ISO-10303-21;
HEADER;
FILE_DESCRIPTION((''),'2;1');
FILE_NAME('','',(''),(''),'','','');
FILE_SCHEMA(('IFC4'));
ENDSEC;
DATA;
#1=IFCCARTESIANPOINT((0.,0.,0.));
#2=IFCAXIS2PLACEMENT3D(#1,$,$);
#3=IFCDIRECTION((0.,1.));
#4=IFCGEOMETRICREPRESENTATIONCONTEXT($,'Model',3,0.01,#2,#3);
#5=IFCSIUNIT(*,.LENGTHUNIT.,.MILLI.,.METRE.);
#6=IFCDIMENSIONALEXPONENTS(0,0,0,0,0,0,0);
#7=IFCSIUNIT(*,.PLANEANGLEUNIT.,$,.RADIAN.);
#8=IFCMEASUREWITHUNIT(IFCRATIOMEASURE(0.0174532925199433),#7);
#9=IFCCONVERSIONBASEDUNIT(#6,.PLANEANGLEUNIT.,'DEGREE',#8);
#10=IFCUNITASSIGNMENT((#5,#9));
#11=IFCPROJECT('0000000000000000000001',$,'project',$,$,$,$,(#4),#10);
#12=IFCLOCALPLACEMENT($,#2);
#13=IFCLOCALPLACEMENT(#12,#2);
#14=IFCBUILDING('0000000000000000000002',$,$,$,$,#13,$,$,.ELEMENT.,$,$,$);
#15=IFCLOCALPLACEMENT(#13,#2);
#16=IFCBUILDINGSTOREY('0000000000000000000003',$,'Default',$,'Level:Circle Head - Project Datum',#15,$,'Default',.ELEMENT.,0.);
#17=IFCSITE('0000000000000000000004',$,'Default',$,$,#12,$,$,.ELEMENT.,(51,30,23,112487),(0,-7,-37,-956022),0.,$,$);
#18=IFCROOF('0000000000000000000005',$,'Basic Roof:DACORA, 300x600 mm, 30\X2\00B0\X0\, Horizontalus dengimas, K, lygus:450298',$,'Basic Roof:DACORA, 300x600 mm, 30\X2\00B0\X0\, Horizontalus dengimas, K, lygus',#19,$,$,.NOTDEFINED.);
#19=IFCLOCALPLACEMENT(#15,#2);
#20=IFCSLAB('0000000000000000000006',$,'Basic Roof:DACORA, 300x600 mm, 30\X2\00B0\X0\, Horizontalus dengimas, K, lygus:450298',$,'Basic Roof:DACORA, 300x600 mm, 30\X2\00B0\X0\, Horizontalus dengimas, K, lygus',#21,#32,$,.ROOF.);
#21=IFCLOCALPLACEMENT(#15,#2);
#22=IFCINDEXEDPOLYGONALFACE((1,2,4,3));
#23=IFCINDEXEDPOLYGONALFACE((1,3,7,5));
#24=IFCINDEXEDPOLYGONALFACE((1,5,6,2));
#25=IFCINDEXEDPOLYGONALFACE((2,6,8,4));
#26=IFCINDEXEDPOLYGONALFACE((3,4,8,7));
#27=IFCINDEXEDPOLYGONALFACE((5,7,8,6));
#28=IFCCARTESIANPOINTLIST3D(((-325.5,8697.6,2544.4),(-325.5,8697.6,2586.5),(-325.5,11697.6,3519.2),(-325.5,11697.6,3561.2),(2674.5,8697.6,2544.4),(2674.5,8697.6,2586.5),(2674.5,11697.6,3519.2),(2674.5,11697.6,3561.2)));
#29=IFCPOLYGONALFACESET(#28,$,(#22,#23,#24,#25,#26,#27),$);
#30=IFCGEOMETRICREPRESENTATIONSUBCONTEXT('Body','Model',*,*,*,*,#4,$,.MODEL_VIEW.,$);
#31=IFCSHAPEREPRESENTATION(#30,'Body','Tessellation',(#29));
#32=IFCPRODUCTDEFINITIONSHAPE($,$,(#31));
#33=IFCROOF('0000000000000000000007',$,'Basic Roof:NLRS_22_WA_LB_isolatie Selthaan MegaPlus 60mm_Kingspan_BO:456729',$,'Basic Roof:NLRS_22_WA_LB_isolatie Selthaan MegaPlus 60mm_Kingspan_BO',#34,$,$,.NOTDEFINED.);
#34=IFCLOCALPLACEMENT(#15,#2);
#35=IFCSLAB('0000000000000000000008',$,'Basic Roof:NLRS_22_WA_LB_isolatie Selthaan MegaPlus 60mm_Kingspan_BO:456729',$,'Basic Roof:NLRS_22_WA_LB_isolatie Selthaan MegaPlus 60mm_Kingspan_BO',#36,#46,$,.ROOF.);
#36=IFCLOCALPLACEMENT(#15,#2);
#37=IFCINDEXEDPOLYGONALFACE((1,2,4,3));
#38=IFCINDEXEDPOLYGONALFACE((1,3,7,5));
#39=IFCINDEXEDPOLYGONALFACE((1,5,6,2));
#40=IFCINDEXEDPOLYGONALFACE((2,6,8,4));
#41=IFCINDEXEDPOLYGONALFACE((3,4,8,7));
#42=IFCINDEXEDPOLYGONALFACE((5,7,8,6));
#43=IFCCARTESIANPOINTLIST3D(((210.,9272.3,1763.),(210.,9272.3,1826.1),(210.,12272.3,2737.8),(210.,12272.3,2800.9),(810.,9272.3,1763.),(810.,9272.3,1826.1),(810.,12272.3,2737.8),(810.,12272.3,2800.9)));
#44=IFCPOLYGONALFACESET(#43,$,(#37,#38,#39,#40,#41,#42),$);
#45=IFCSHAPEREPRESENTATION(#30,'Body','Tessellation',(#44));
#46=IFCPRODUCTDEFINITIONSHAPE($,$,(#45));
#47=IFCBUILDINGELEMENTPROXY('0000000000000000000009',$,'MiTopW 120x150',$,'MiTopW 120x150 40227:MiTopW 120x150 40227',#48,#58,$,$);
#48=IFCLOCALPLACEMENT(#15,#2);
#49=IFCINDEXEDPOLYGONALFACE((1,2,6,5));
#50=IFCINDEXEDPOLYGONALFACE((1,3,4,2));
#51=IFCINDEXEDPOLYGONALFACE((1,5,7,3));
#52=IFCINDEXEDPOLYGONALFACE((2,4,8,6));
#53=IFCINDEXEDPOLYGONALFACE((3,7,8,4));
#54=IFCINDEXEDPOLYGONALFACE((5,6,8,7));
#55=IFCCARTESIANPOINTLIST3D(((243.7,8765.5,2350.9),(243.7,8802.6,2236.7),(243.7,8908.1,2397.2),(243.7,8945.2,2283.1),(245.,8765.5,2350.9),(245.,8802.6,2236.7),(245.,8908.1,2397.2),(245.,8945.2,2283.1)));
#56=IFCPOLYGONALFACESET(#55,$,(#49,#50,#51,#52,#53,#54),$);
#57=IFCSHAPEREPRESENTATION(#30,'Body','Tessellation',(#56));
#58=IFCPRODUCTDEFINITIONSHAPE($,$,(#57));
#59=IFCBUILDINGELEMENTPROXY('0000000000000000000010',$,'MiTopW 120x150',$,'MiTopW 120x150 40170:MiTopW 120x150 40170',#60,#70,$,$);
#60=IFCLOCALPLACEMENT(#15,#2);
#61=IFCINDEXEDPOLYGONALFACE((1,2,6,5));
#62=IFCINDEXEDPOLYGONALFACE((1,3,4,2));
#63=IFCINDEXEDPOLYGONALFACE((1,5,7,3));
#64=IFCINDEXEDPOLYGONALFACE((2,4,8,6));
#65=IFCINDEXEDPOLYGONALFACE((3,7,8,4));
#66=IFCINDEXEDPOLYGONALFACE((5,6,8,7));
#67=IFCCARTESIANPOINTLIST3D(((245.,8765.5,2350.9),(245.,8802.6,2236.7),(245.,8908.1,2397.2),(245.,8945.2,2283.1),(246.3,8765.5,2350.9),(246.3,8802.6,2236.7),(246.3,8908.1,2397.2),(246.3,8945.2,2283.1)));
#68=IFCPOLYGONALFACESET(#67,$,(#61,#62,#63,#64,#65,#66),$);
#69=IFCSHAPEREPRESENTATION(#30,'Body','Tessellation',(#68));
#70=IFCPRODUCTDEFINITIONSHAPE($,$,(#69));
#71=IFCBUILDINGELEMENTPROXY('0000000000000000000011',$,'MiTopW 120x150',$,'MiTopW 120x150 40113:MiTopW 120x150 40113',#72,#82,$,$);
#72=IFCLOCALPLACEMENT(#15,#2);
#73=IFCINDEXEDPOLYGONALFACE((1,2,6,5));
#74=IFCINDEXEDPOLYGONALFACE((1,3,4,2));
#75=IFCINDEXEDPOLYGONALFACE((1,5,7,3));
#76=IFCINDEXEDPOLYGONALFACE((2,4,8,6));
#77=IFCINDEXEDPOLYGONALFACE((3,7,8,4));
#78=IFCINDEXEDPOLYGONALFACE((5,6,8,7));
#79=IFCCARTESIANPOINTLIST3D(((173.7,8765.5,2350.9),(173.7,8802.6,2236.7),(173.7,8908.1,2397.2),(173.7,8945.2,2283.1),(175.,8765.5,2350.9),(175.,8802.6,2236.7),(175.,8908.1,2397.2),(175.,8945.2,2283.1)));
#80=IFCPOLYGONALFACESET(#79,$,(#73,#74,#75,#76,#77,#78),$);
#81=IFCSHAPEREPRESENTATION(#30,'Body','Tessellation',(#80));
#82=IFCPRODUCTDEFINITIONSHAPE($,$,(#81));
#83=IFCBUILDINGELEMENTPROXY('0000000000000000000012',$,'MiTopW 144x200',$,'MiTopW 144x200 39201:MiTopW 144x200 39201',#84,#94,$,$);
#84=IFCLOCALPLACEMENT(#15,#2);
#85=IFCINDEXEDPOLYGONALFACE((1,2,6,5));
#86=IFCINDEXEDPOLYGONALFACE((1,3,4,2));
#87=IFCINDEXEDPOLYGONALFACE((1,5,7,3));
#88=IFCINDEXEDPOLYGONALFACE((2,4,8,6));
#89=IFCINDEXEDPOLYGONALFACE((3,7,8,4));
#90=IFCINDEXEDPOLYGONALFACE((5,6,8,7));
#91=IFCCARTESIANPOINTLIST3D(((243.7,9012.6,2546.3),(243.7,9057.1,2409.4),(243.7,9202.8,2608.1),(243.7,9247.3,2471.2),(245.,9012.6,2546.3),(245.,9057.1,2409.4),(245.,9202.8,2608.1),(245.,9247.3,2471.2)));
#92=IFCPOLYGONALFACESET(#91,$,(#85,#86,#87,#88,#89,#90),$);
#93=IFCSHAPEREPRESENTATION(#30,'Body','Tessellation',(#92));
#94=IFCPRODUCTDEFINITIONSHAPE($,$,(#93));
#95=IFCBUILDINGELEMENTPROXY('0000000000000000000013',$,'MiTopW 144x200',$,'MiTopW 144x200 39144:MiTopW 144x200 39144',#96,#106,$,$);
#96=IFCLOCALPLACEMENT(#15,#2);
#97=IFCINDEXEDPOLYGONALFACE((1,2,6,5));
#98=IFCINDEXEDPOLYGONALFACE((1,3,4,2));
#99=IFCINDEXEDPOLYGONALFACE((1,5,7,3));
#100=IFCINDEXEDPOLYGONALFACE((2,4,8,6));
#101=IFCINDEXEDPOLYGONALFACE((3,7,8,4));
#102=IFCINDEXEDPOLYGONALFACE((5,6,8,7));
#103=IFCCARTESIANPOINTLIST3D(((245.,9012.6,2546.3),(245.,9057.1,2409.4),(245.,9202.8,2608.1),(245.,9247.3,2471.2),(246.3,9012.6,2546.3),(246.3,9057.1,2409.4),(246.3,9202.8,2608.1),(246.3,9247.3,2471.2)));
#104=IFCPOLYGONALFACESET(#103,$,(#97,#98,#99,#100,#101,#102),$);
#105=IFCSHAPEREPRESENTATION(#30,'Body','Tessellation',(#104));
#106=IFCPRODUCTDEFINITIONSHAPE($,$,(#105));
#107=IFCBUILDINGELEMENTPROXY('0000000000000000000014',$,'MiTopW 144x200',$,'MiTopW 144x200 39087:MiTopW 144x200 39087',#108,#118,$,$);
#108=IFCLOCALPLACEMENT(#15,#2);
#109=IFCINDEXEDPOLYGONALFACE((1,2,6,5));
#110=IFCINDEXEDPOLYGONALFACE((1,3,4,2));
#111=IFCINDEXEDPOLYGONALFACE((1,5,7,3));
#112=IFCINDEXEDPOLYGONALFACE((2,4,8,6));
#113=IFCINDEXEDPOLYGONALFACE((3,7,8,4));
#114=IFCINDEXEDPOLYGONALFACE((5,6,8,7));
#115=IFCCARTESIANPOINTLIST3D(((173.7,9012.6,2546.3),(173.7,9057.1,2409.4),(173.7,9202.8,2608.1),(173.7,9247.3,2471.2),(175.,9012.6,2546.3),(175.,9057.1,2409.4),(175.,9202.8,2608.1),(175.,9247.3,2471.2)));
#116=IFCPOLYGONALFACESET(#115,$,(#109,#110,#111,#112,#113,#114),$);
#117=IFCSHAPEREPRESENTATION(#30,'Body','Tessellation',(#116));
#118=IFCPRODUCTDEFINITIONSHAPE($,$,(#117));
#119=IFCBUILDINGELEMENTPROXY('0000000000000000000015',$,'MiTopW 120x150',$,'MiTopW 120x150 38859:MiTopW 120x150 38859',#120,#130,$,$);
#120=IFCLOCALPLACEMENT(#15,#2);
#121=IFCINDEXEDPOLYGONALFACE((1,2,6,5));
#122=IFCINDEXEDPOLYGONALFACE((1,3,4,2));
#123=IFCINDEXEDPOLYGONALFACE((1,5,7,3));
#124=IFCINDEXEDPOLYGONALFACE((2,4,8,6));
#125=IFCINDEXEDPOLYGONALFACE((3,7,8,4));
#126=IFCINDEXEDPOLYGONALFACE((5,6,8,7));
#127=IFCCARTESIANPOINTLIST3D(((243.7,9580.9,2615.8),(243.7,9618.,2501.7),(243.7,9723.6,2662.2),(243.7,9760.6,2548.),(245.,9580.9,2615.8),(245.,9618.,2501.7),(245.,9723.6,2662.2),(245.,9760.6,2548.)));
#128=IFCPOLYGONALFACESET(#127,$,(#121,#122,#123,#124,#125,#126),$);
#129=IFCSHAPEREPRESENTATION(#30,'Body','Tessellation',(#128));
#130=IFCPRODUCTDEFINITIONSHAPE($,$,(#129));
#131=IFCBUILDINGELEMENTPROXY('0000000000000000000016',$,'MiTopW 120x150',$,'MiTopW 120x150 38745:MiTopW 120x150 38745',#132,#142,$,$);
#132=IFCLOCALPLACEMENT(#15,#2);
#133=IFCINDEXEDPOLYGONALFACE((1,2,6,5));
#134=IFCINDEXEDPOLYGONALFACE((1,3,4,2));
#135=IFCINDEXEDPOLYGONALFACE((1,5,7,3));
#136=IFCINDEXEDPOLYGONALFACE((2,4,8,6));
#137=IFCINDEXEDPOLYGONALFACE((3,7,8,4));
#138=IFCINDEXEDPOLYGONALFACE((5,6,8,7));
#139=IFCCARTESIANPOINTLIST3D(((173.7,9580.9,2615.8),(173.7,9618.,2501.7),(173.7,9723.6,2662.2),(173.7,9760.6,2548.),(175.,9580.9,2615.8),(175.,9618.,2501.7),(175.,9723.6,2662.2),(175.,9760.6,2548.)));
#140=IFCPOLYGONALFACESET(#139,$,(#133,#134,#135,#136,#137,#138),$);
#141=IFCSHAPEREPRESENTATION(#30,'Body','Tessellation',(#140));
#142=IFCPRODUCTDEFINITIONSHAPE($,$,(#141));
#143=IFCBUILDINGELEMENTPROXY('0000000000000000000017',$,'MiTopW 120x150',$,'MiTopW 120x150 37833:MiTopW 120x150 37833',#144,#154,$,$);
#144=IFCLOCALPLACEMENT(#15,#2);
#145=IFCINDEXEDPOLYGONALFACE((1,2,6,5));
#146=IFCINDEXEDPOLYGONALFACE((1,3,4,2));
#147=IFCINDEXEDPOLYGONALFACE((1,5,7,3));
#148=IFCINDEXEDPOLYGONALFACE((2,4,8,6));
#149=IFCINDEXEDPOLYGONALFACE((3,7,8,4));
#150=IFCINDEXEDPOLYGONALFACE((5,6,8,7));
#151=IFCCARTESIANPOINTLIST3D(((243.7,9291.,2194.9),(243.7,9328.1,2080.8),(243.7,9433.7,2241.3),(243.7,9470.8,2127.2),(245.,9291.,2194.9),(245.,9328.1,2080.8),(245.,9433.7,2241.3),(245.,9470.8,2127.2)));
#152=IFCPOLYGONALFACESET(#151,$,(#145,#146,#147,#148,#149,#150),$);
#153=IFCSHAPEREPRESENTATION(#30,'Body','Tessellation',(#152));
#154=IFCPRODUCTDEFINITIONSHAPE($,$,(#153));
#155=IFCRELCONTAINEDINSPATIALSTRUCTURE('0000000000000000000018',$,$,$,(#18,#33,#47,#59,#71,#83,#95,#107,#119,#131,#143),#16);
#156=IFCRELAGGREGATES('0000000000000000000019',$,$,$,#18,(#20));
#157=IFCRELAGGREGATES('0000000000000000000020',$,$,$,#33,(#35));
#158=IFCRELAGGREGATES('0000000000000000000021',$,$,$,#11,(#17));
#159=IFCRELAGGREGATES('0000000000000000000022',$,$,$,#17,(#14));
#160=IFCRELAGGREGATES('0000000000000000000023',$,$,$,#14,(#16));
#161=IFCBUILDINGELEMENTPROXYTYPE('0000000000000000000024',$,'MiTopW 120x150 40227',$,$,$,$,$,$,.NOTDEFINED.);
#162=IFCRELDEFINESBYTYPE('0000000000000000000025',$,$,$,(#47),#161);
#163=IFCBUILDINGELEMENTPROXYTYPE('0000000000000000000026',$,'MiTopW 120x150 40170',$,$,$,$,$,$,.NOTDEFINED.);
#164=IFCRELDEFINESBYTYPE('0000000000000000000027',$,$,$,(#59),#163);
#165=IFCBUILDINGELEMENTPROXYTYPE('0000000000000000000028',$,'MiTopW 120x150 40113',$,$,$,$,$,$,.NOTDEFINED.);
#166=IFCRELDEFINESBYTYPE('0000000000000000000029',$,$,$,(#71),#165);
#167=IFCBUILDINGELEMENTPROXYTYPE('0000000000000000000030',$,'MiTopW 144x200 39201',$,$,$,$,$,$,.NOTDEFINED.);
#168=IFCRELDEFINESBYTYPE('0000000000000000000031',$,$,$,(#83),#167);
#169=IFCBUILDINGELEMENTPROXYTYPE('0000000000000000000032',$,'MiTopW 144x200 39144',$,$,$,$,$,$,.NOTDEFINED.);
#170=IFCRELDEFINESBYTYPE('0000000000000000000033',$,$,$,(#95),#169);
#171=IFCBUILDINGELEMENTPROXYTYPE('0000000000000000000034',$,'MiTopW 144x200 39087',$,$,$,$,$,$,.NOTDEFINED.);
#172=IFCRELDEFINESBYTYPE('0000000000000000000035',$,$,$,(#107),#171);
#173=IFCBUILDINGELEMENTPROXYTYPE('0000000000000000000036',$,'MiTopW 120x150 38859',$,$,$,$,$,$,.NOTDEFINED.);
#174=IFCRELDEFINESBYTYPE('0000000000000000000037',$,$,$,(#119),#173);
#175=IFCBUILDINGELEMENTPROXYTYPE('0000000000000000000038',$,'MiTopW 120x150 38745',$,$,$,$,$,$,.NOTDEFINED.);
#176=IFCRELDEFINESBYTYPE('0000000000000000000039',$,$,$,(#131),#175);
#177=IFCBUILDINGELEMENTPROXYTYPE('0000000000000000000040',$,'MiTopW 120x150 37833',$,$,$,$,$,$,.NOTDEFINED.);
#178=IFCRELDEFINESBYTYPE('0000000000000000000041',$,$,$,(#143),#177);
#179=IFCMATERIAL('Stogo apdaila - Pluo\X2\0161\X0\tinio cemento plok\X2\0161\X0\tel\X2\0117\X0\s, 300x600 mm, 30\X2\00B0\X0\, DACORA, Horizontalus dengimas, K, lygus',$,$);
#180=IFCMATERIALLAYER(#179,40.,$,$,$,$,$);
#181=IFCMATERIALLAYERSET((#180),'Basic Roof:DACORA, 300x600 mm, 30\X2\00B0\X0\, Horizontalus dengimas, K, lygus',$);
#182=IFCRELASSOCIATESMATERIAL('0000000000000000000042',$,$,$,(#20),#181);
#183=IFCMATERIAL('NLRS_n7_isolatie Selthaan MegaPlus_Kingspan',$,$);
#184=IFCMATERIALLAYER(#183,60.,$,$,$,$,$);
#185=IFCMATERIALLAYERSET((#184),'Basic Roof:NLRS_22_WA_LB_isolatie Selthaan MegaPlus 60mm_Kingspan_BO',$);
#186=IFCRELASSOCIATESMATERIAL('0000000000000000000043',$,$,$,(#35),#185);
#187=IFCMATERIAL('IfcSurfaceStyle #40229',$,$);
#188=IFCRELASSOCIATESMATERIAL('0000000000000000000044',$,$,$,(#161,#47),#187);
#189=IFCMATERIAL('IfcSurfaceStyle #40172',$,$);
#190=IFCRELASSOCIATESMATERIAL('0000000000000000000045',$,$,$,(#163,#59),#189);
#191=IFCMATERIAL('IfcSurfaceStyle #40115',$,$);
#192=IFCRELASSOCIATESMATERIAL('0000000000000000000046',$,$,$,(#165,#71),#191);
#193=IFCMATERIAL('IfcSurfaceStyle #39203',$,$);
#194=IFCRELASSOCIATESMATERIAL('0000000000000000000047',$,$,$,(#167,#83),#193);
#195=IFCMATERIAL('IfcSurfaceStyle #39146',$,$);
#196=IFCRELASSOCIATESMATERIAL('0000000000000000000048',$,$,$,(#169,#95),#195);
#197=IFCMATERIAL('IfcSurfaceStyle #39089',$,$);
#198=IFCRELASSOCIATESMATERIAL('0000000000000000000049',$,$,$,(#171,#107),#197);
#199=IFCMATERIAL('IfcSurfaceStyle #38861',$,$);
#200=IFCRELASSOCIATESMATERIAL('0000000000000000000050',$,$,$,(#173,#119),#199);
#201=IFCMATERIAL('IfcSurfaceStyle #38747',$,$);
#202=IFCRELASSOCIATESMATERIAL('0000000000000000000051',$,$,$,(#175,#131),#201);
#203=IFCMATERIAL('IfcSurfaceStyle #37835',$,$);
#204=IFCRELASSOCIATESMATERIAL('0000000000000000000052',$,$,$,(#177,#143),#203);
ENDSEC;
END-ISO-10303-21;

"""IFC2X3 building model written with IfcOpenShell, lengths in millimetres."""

from ifc_helpers import new_model, entity, si_unit, converted_unit, direction, frame, frame_2d, origin, place, context, subcontext, project, spatial, polyline, rectangle, outline, extrude, source, transform, mapped, material, layer, layer_set, type_object, type_shapes, element, aggregate, save


model = new_model("IFC2X3")

# Units and contexts
model_context = context("Model", 3, precision=0.01, world=origin(), true_north=direction((0.0, 1.0)))
body_context = subcontext(model_context, "Body", "Model", "MODEL_VIEW")
ifc_project = project(units=[si_unit("LENGTHUNIT", "METRE", prefix="MILLI"), converted_unit("PLANEANGLEUNIT", "DEGREE", entity("IfcRatioMeasure", 0.0174532925199433), si_unit("PLANEANGLEUNIT", "RADIAN"), dimensions=[0, 0, 0, 0, 0, 0, 0])], contexts=[model_context])

# Site, building, storey
site_placement = place(None, origin())
site = spatial("IfcSite", under=ifc_project, at=site_placement, Name="Default", CompositionType="ELEMENT", RefLatitude=(51, 30, 23, 112487), RefLongitude=(0, -7, -37, -956022), RefElevation=0.0)
building_placement = place(site_placement, origin())
building = spatial("IfcBuilding", under=site, at=building_placement, CompositionType="ELEMENT")
storey_placement = place(building_placement, origin())
storey = spatial("IfcBuildingStorey", under=building, at=storey_placement, Name="Default", ObjectType="Level:Circle Head - Project Datum", LongName="Default", CompositionType="ELEMENT", Elevation=0.0)

# Roofs, slabs
roof_1_placement = place(building_placement, frame((-325.5, 8697.6, 2544.4)))
roof_1 = element("IfcRoof", 1, at=roof_1_placement, inside=storey, Name="Basic Roof:DACORA, 300x600 mm, 30°, Horizontalus dengimas, K, lygus:450298", ObjectType="Basic Roof:DACORA, 300x600 mm, 30°, Horizontalus dengimas, K, lygus", ShapeType="NOTDEFINED")
ifc_material_1 = material(Name="Stogo apdaila - Pluoštinio cemento plokštelės, 300x600 mm, 30°, DACORA, Horizontalus dengimas, K, lygus")
ifc_layer_1 = layer(ifc_material_1, 40.0)
ifc_layer_set_1 = layer_set([ifc_layer_1], Name="Basic Roof:DACORA, 300x600 mm, 30°, Horizontalus dengimas, K, lygus")
slab_1_placement = place(roof_1_placement, origin())
slab_1 = element("IfcSlab", 2, at=slab_1_placement, material=ifc_layer_set_1, Name="Basic Roof:DACORA, 300x600 mm, 30°, Horizontalus dengimas, K, lygus:450298", ObjectType="Basic Roof:DACORA, 300x600 mm, 30°, Horizontalus dengimas, K, lygus", PredefinedType="ROOF", context=body_context, shape_type="SweptSolid", body=[
    extrude(rectangle(XDim=3154.4, YDim=3000.0, at=frame_2d((0.0, 0.0), x_axis=(0.0, -1.0))), frame((1500.0, 1500.0, 487.4), z_axis=(0.0, -0.309017, 0.951057), x_axis=(1.0, 0.0, 0.0)), (0.0, 0.309017, 0.951057), 42.1),
])
aggregate(roof_1, [slab_1])
roof_2_placement = place(storey_placement, frame((210.0, 9272.3, 1763.0)))
roof_2 = element("IfcRoof", 3, at=roof_2_placement, inside=storey, Name="Basic Roof:NLRS_22_WA_LB_isolatie Selthaan MegaPlus 60mm_Kingspan_BO:456729", ObjectType="Basic Roof:NLRS_22_WA_LB_isolatie Selthaan MegaPlus 60mm_Kingspan_BO", ShapeType="NOTDEFINED")
ifc_material_2 = material(Name="NLRS_n7_isolatie Selthaan MegaPlus_Kingspan")
ifc_layer_2 = layer(ifc_material_2, 60.0)
ifc_layer_set_2 = layer_set([ifc_layer_2], Name="Basic Roof:NLRS_22_WA_LB_isolatie Selthaan MegaPlus 60mm_Kingspan_BO")
slab_2_placement = place(roof_2_placement, origin())
slab_2 = element("IfcSlab", 4, at=slab_2_placement, material=ifc_layer_set_2, Name="Basic Roof:NLRS_22_WA_LB_isolatie Selthaan MegaPlus 60mm_Kingspan_BO:456729", ObjectType="Basic Roof:NLRS_22_WA_LB_isolatie Selthaan MegaPlus 60mm_Kingspan_BO", PredefinedType="ROOF", context=body_context, shape_type="SweptSolid", body=[
    extrude(rectangle(XDim=600.0, YDim=3154.4, at=frame_2d((0.0, 0.0), x_axis=(-1.0, 0.0))), frame((300.0, 1500.0, 487.4), z_axis=(0.0, -0.309017, 0.951057), x_axis=(1.0, 0.0, 0.0)), (0.0, 0.309017, 0.951057), 63.1),
])
aggregate(roof_2, [slab_2])

# Building element proxies
ifc_material_3 = material(Name="IfcSurfaceStyle #40229")
building_element_proxy_type_1 = type_object("IfcBuildingElementProxyType", Name="MiTopW 120x150 40227", PredefinedType="NOTDEFINED", material=ifc_material_3)
shared_shape_1 = source(origin(), body_context, "Body", "SweptSolid", [
    extrude(outline(polyline([(-75.0, -60.0), (75.0, -60.0), (75.0, 60.0), (-75.0, 60.0), (-75.0, -60.0)])), frame((75.0, 60.0, 0.0), z_axis=(0.0, 0.0, 1.0), x_axis=(-1.0, 0.0, 0.0)), (0.0, 0.0, 1.0), 1.3),
])
type_shapes(building_element_proxy_type_1, [shared_shape_1])
proxy_1_placement = place(building_placement, frame((245.0, 8765.5, 2350.9), z_axis=(-1.0, 0.0, 0.0), x_axis=(0.0, 0.951057, 0.309017)))
element("IfcBuildingElementProxy", 5, at=proxy_1_placement, inside=storey, type_object=building_element_proxy_type_1, material=ifc_material_3, Name="MiTopW 120x150", ObjectType="MiTopW 120x150 40227:MiTopW 120x150 40227", context=body_context, shape_type="MappedRepresentation", body=[
    mapped(shared_shape_1, transform((0.0, 0.0, 0.0), scale=1.0)),
])
ifc_material_4 = material(Name="IfcSurfaceStyle #40172")
building_element_proxy_type_2 = type_object("IfcBuildingElementProxyType", Name="MiTopW 120x150 40170", PredefinedType="NOTDEFINED", material=ifc_material_4)
shared_shape_2 = source(origin(), body_context, "Body", "SweptSolid", [
    extrude(outline(polyline([(-75.0, -60.0), (75.0, -60.0), (75.0, 60.0), (-75.0, 60.0), (-75.0, -60.0)])), frame((75.0, 60.0, 0.0), z_axis=(0.0, 0.0, 1.0), x_axis=(-1.0, 0.0, 0.0)), (0.0, 0.0, 1.0), 1.3),
])
type_shapes(building_element_proxy_type_2, [shared_shape_2])
proxy_2_placement = place(building_placement, frame((246.3, 8765.5, 2350.9), z_axis=(-1.0, 0.0, 0.0), x_axis=(0.0, 0.951057, 0.309017)))
element("IfcBuildingElementProxy", 6, at=proxy_2_placement, inside=storey, type_object=building_element_proxy_type_2, material=ifc_material_4, Name="MiTopW 120x150", ObjectType="MiTopW 120x150 40170:MiTopW 120x150 40170", context=body_context, shape_type="MappedRepresentation", body=[
    mapped(shared_shape_2, transform((0.0, 0.0, 0.0), scale=1.0)),
])
ifc_material_5 = material(Name="IfcSurfaceStyle #40115")
building_element_proxy_type_3 = type_object("IfcBuildingElementProxyType", Name="MiTopW 120x150 40113", PredefinedType="NOTDEFINED", material=ifc_material_5)
shared_shape_3 = source(origin(), body_context, "Body", "SweptSolid", [
    extrude(outline(polyline([(-75.0, -60.0), (75.0, -60.0), (75.0, 60.0), (-75.0, 60.0), (-75.0, -60.0)])), frame((75.0, 60.0, 0.0), z_axis=(0.0, 0.0, 1.0), x_axis=(-1.0, 0.0, 0.0)), (0.0, 0.0, 1.0), 1.3),
])
type_shapes(building_element_proxy_type_3, [shared_shape_3])
proxy_3_placement = place(building_placement, frame((175.0, 8765.5, 2350.9), z_axis=(-1.0, 0.0, 0.0), x_axis=(0.0, 0.951057, 0.309017)))
element("IfcBuildingElementProxy", 7, at=proxy_3_placement, inside=storey, type_object=building_element_proxy_type_3, material=ifc_material_5, Name="MiTopW 120x150", ObjectType="MiTopW 120x150 40113:MiTopW 120x150 40113", context=body_context, shape_type="MappedRepresentation", body=[
    mapped(shared_shape_3, transform((0.0, 0.0, 0.0), scale=1.0)),
])
ifc_material_6 = material(Name="IfcSurfaceStyle #39203")
building_element_proxy_type_4 = type_object("IfcBuildingElementProxyType", Name="MiTopW 144x200 39201", PredefinedType="NOTDEFINED", material=ifc_material_6)
shared_shape_4 = source(origin(), body_context, "Body", "SweptSolid", [
    extrude(outline(polyline([(-100.0, -72.0), (100.0, -72.0), (100.0, 72.0), (-100.0, 72.0), (-100.0, -72.0)])), frame((100.0, 72.0, 0.0), z_axis=(0.0, 0.0, 1.0), x_axis=(-1.0, 0.0, 0.0)), (0.0, 0.0, 1.0), 1.3),
])
type_shapes(building_element_proxy_type_4, [shared_shape_4])
proxy_4_placement = place(building_placement, frame((245.0, 9012.6, 2546.3), z_axis=(-1.0, 0.0, 0.0), x_axis=(0.0, 0.951057, 0.309017)))
element("IfcBuildingElementProxy", 8, at=proxy_4_placement, inside=storey, type_object=building_element_proxy_type_4, material=ifc_material_6, Name="MiTopW 144x200", ObjectType="MiTopW 144x200 39201:MiTopW 144x200 39201", context=body_context, shape_type="MappedRepresentation", body=[
    mapped(shared_shape_4, transform((0.0, 0.0, 0.0), scale=1.0)),
])
ifc_material_7 = material(Name="IfcSurfaceStyle #39146")
building_element_proxy_type_5 = type_object("IfcBuildingElementProxyType", Name="MiTopW 144x200 39144", PredefinedType="NOTDEFINED", material=ifc_material_7)
shared_shape_5 = source(origin(), body_context, "Body", "SweptSolid", [
    extrude(outline(polyline([(-100.0, -72.0), (100.0, -72.0), (100.0, 72.0), (-100.0, 72.0), (-100.0, -72.0)])), frame((100.0, 72.0, 0.0), z_axis=(0.0, 0.0, 1.0), x_axis=(-1.0, 0.0, 0.0)), (0.0, 0.0, 1.0), 1.3),
])
type_shapes(building_element_proxy_type_5, [shared_shape_5])
proxy_5_placement = place(building_placement, frame((246.3, 9012.6, 2546.3), z_axis=(-1.0, 0.0, 0.0), x_axis=(0.0, 0.951057, 0.309017)))
element("IfcBuildingElementProxy", 9, at=proxy_5_placement, inside=storey, type_object=building_element_proxy_type_5, material=ifc_material_7, Name="MiTopW 144x200", ObjectType="MiTopW 144x200 39144:MiTopW 144x200 39144", context=body_context, shape_type="MappedRepresentation", body=[
    mapped(shared_shape_5, transform((0.0, 0.0, 0.0), scale=1.0)),
])
ifc_material_8 = material(Name="IfcSurfaceStyle #39089")
building_element_proxy_type_6 = type_object("IfcBuildingElementProxyType", Name="MiTopW 144x200 39087", PredefinedType="NOTDEFINED", material=ifc_material_8)
shared_shape_6 = source(origin(), body_context, "Body", "SweptSolid", [
    extrude(outline(polyline([(-100.0, -72.0), (100.0, -72.0), (100.0, 72.0), (-100.0, 72.0), (-100.0, -72.0)])), frame((100.0, 72.0, 0.0), z_axis=(0.0, 0.0, 1.0), x_axis=(-1.0, 0.0, 0.0)), (0.0, 0.0, 1.0), 1.3),
])
type_shapes(building_element_proxy_type_6, [shared_shape_6])
proxy_6_placement = place(building_placement, frame((175.0, 9012.6, 2546.3), z_axis=(-1.0, 0.0, 0.0), x_axis=(0.0, 0.951057, 0.309017)))
element("IfcBuildingElementProxy", 10, at=proxy_6_placement, inside=storey, type_object=building_element_proxy_type_6, material=ifc_material_8, Name="MiTopW 144x200", ObjectType="MiTopW 144x200 39087:MiTopW 144x200 39087", context=body_context, shape_type="MappedRepresentation", body=[
    mapped(shared_shape_6, transform((0.0, 0.0, 0.0), scale=1.0)),
])
ifc_material_9 = material(Name="IfcSurfaceStyle #38861")
building_element_proxy_type_7 = type_object("IfcBuildingElementProxyType", Name="MiTopW 120x150 38859", PredefinedType="NOTDEFINED", material=ifc_material_9)
shared_shape_7 = source(origin(), body_context, "Body", "SweptSolid", [
    extrude(outline(polyline([(-75.0, -60.0), (75.0, -60.0), (75.0, 60.0), (-75.0, 60.0), (-75.0, -60.0)])), frame((75.0, 60.0, 0.0), z_axis=(0.0, 0.0, 1.0), x_axis=(-1.0, 0.0, 0.0)), (0.0, 0.0, 1.0), 1.3),
])
type_shapes(building_element_proxy_type_7, [shared_shape_7])
proxy_7_placement = place(building_placement, frame((245.0, 9580.9, 2615.8), z_axis=(-1.0, 0.0, 0.0), x_axis=(0.0, 0.951057, 0.309017)))
element("IfcBuildingElementProxy", 11, at=proxy_7_placement, inside=storey, type_object=building_element_proxy_type_7, material=ifc_material_9, Name="MiTopW 120x150", ObjectType="MiTopW 120x150 38859:MiTopW 120x150 38859", context=body_context, shape_type="MappedRepresentation", body=[
    mapped(shared_shape_7, transform((0.0, 0.0, 0.0), scale=1.0)),
])
ifc_material_10 = material(Name="IfcSurfaceStyle #38747")
building_element_proxy_type_8 = type_object("IfcBuildingElementProxyType", Name="MiTopW 120x150 38745", PredefinedType="NOTDEFINED", material=ifc_material_10)
shared_shape_8 = source(origin(), body_context, "Body", "SweptSolid", [
    extrude(outline(polyline([(-75.0, -60.0), (75.0, -60.0), (75.0, 60.0), (-75.0, 60.0), (-75.0, -60.0)])), frame((75.0, 60.0, 0.0), z_axis=(0.0, 0.0, 1.0), x_axis=(-1.0, 0.0, 0.0)), (0.0, 0.0, 1.0), 1.3),
])
type_shapes(building_element_proxy_type_8, [shared_shape_8])
proxy_8_placement = place(building_placement, frame((175.0, 9580.9, 2615.8), z_axis=(-1.0, 0.0, 0.0), x_axis=(0.0, 0.951057, 0.309017)))
element("IfcBuildingElementProxy", 12, at=proxy_8_placement, inside=storey, type_object=building_element_proxy_type_8, material=ifc_material_10, Name="MiTopW 120x150", ObjectType="MiTopW 120x150 38745:MiTopW 120x150 38745", context=body_context, shape_type="MappedRepresentation", body=[
    mapped(shared_shape_8, transform((0.0, 0.0, 0.0), scale=1.0)),
])
ifc_material_11 = material(Name="IfcSurfaceStyle #37835")
building_element_proxy_type_9 = type_object("IfcBuildingElementProxyType", Name="MiTopW 120x150 37833", PredefinedType="NOTDEFINED", material=ifc_material_11)
shared_shape_9 = source(origin(), body_context, "Body", "SweptSolid", [
    extrude(outline(polyline([(-75.0, -60.0), (75.0, -60.0), (75.0, 60.0), (-75.0, 60.0), (-75.0, -60.0)])), frame((75.0, 60.0, 0.0), z_axis=(0.0, 0.0, 1.0), x_axis=(-1.0, 0.0, 0.0)), (0.0, 0.0, 1.0), 1.3),
])
type_shapes(building_element_proxy_type_9, [shared_shape_9])
proxy_9_placement = place(building_placement, frame((245.0, 9291.0, 2194.9), z_axis=(-1.0, 0.0, 0.0), x_axis=(0.0, 0.951057, 0.309017)))
element("IfcBuildingElementProxy", 13, at=proxy_9_placement, inside=storey, type_object=building_element_proxy_type_9, material=ifc_material_11, Name="MiTopW 120x150", ObjectType="MiTopW 120x150 37833:MiTopW 120x150 37833", context=body_context, shape_type="MappedRepresentation", body=[
    mapped(shared_shape_9, transform((0.0, 0.0, 0.0), scale=1.0)),
])

save(model, "model.ifc")
